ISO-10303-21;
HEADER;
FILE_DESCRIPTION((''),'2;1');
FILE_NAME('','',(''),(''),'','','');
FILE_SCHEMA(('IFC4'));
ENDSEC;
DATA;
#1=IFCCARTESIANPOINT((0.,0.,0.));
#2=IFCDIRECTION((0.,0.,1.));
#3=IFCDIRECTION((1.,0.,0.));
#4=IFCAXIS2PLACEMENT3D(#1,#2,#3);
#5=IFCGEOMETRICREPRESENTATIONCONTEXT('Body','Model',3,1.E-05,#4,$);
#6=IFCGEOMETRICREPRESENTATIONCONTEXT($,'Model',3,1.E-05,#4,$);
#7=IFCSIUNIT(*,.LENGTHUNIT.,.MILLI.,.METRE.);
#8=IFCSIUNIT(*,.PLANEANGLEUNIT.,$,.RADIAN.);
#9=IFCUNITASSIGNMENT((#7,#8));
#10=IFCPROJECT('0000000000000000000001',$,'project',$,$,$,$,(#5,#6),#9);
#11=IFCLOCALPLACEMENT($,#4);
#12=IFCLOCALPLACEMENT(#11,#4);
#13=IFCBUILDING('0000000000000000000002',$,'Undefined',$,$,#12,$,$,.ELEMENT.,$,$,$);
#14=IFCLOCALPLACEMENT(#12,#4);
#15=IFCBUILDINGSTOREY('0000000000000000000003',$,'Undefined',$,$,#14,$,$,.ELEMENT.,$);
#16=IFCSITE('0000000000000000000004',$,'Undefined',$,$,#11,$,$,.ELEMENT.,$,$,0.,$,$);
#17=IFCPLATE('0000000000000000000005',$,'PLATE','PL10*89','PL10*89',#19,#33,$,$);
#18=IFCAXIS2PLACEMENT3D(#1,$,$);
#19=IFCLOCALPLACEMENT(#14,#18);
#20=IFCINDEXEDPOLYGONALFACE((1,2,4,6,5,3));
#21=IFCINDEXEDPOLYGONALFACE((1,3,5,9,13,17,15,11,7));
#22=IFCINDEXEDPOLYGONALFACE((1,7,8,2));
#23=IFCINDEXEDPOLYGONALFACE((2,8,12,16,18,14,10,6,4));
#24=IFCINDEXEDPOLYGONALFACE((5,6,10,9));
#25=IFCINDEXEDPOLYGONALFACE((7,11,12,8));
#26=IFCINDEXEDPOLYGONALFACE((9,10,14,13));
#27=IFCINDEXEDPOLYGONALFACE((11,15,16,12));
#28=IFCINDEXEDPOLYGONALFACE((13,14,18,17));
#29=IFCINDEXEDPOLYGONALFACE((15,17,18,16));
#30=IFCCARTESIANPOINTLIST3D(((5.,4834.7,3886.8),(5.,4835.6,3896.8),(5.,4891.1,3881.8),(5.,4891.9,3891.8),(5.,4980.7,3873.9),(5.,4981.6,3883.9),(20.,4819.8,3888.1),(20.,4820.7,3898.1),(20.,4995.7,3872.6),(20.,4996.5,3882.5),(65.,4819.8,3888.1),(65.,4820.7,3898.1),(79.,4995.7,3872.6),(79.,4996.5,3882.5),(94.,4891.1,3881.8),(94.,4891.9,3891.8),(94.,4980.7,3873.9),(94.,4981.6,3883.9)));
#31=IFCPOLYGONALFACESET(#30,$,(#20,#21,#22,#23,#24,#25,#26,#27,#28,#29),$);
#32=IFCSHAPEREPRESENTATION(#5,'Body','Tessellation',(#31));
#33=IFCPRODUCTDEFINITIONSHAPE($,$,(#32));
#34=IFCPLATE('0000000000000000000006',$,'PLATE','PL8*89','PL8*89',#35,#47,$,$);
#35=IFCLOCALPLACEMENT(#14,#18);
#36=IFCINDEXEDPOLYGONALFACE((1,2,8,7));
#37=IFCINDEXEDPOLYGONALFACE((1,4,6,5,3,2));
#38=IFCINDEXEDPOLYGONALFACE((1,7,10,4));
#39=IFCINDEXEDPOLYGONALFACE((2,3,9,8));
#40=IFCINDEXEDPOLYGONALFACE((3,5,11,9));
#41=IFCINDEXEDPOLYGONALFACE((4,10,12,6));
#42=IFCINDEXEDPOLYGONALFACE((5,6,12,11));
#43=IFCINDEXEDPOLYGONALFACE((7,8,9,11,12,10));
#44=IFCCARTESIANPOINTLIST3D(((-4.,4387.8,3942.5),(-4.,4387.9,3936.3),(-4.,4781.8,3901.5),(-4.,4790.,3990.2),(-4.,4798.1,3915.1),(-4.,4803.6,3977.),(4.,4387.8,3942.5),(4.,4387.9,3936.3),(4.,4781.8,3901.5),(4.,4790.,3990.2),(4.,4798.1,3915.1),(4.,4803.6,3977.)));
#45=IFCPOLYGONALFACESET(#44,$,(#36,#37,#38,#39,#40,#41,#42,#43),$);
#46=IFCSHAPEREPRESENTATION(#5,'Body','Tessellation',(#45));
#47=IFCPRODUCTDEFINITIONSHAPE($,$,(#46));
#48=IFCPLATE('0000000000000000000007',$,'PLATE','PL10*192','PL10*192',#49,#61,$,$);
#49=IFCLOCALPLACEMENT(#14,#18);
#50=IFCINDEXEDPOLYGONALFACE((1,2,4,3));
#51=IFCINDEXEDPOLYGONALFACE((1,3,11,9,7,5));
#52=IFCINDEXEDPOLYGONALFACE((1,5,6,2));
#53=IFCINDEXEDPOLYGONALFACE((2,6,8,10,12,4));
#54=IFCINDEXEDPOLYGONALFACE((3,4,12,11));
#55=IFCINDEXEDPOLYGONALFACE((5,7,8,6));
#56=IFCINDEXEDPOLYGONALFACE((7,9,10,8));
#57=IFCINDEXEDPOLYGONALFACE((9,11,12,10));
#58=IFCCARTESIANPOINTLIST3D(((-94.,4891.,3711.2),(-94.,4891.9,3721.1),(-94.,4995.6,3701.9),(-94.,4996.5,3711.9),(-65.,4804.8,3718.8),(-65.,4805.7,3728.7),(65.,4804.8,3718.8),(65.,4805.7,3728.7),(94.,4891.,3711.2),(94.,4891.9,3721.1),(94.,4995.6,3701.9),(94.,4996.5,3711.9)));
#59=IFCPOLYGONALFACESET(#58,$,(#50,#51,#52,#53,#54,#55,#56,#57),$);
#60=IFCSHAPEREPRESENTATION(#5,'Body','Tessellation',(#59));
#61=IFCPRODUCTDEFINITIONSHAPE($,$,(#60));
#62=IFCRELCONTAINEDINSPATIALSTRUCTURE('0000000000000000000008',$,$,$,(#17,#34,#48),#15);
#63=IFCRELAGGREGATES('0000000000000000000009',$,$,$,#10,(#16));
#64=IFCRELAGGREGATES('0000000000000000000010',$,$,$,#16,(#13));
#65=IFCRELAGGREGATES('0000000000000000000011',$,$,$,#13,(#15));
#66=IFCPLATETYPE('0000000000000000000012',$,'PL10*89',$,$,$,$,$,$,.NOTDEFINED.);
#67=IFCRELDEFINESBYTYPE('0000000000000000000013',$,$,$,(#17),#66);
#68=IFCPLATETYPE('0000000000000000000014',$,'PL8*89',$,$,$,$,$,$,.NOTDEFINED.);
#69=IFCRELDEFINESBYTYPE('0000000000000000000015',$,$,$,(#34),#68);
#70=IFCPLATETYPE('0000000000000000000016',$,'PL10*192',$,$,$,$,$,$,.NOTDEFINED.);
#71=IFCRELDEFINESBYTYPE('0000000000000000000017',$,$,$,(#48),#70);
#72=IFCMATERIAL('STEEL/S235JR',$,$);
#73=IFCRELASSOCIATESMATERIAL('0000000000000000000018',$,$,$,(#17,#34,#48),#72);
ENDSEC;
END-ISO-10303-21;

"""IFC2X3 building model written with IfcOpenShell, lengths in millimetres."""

from ifc_helpers import new_model, si_unit, frame, origin_with_axes, place, context, project, spatial, polyline, outline, extrude, material, type_object, element, save


model = new_model("IFC2X3")

# Units and contexts
model_context_1 = context("Model", 3, precision=1e-05, world=origin_with_axes(), identifier="Body")
model_context_2 = context("Model", 3, precision=1e-05, world=origin_with_axes())
ifc_project = project(units=[si_unit("LENGTHUNIT", "METRE", prefix="MILLI"), si_unit("PLANEANGLEUNIT", "RADIAN")], contexts=[model_context_1, model_context_2])

# Site, building, storey
site_placement = place(None, origin_with_axes())
site = spatial("IfcSite", under=ifc_project, at=site_placement, Name="Undefined", CompositionType="ELEMENT", RefElevation=0.0)
building_placement = place(site_placement, origin_with_axes())
building = spatial("IfcBuilding", under=site, at=building_placement, Name="Undefined", CompositionType="ELEMENT")
storey_placement = place(building_placement, origin_with_axes())
storey = spatial("IfcBuildingStorey", under=building, at=storey_placement, Name="Undefined", CompositionType="ELEMENT")

# Shared definitions
ifc_material = material(Name="STEEL/S235JR")

# Plates
plate_type_1 = type_object("IfcPlateType", Name="PL10*89", PredefinedType="NOTDEFINED")
for number, where, z_axis, x_axis, name in (
    (1, (5.0, 4820.2, 3893.1), (0.0, -0.08801, -0.99612), (0.0, 0.99612, -0.08801), "PLATE"),
):
    element("IfcPlate", number, at=place(storey_placement, frame(where, z_axis=z_axis, x_axis=x_axis)), inside=storey, type_object=plate_type_1, material=ifc_material, Name=name, Description="PL10*89", ObjectType="PL10*89", context=model_context_1, shape_type="SweptSolid", body=[
        extrude(outline(polyline([(0.0, 15.0), (15.0, 0.0), (71.6, 0.0), (161.6, 0.0), (176.6, 15.0), (176.6, 74.0), (161.6, 89.0), (71.6, 89.0), (0.0, 60.0), (0.0, 15.0)])), frame((0.0, 0.0, -5.0), z_axis=(0.0, 0.0, 1.0), x_axis=(1.0, 0.0, 0.0)), (0.0, 0.0, 1.0), 10.0),
    ])
plate_type_2 = type_object("IfcPlateType", Name="PL8*89", PredefinedType="NOTDEFINED")
plate_1_placement = place(storey_placement, frame((0.0, 4796.8, 3900.2), z_axis=(1.0, 0.0, 0.0), x_axis=(0.0, 0.087999, 0.996121)))
element("IfcPlate", 2, at=plate_1_placement, inside=storey, type_object=plate_type_2, material=ifc_material, Name="PLATE", Description="PL8*89", ObjectType="PL8*89", context=model_context_1, shape_type="SweptSolid", body=[
    extrude(outline(polyline([(0.0, 15.0), (15.0, 0.0), (77.1, 0.0), (89.0, 14.7), (6.1, 411.1), (0.0, 410.5), (0.0, 15.0)])), frame((0.0, 0.0, -4.0), z_axis=(0.0, 0.0, 1.0), x_axis=(1.0, 0.0, 0.0)), (0.0, 0.0, 1.0), 8.0),
])
plate_type_3 = type_object("IfcPlateType", Name="PL10*192", PredefinedType="NOTDEFINED")
plate_2_placement = place(storey_placement, frame((65.0, 4805.3, 3723.8), z_axis=(0.0, 0.08801, 0.99612), x_axis=(0.317772, 0.944488, -0.083449)))
element("IfcPlate", 3, at=plate_2_placement, inside=storey, type_object=plate_type_3, material=ifc_material, Name="PLATE", Description="PL10*192", ObjectType="PL10*192", context=model_context_1, shape_type="SweptSolid", body=[
    extrude(outline(polyline([(0.0, 0.0), (91.3, 0.0), (190.8, 33.4), (131.1, 211.6), (31.5, 178.3), (-41.3, 123.3), (0.0, 0.0)])), frame((0.0, 0.0, -5.0), z_axis=(0.0, 0.0, 1.0), x_axis=(1.0, 0.0, 0.0)), (0.0, 0.0, 1.0), 10.0),
])

save(model, "model.ifc")
